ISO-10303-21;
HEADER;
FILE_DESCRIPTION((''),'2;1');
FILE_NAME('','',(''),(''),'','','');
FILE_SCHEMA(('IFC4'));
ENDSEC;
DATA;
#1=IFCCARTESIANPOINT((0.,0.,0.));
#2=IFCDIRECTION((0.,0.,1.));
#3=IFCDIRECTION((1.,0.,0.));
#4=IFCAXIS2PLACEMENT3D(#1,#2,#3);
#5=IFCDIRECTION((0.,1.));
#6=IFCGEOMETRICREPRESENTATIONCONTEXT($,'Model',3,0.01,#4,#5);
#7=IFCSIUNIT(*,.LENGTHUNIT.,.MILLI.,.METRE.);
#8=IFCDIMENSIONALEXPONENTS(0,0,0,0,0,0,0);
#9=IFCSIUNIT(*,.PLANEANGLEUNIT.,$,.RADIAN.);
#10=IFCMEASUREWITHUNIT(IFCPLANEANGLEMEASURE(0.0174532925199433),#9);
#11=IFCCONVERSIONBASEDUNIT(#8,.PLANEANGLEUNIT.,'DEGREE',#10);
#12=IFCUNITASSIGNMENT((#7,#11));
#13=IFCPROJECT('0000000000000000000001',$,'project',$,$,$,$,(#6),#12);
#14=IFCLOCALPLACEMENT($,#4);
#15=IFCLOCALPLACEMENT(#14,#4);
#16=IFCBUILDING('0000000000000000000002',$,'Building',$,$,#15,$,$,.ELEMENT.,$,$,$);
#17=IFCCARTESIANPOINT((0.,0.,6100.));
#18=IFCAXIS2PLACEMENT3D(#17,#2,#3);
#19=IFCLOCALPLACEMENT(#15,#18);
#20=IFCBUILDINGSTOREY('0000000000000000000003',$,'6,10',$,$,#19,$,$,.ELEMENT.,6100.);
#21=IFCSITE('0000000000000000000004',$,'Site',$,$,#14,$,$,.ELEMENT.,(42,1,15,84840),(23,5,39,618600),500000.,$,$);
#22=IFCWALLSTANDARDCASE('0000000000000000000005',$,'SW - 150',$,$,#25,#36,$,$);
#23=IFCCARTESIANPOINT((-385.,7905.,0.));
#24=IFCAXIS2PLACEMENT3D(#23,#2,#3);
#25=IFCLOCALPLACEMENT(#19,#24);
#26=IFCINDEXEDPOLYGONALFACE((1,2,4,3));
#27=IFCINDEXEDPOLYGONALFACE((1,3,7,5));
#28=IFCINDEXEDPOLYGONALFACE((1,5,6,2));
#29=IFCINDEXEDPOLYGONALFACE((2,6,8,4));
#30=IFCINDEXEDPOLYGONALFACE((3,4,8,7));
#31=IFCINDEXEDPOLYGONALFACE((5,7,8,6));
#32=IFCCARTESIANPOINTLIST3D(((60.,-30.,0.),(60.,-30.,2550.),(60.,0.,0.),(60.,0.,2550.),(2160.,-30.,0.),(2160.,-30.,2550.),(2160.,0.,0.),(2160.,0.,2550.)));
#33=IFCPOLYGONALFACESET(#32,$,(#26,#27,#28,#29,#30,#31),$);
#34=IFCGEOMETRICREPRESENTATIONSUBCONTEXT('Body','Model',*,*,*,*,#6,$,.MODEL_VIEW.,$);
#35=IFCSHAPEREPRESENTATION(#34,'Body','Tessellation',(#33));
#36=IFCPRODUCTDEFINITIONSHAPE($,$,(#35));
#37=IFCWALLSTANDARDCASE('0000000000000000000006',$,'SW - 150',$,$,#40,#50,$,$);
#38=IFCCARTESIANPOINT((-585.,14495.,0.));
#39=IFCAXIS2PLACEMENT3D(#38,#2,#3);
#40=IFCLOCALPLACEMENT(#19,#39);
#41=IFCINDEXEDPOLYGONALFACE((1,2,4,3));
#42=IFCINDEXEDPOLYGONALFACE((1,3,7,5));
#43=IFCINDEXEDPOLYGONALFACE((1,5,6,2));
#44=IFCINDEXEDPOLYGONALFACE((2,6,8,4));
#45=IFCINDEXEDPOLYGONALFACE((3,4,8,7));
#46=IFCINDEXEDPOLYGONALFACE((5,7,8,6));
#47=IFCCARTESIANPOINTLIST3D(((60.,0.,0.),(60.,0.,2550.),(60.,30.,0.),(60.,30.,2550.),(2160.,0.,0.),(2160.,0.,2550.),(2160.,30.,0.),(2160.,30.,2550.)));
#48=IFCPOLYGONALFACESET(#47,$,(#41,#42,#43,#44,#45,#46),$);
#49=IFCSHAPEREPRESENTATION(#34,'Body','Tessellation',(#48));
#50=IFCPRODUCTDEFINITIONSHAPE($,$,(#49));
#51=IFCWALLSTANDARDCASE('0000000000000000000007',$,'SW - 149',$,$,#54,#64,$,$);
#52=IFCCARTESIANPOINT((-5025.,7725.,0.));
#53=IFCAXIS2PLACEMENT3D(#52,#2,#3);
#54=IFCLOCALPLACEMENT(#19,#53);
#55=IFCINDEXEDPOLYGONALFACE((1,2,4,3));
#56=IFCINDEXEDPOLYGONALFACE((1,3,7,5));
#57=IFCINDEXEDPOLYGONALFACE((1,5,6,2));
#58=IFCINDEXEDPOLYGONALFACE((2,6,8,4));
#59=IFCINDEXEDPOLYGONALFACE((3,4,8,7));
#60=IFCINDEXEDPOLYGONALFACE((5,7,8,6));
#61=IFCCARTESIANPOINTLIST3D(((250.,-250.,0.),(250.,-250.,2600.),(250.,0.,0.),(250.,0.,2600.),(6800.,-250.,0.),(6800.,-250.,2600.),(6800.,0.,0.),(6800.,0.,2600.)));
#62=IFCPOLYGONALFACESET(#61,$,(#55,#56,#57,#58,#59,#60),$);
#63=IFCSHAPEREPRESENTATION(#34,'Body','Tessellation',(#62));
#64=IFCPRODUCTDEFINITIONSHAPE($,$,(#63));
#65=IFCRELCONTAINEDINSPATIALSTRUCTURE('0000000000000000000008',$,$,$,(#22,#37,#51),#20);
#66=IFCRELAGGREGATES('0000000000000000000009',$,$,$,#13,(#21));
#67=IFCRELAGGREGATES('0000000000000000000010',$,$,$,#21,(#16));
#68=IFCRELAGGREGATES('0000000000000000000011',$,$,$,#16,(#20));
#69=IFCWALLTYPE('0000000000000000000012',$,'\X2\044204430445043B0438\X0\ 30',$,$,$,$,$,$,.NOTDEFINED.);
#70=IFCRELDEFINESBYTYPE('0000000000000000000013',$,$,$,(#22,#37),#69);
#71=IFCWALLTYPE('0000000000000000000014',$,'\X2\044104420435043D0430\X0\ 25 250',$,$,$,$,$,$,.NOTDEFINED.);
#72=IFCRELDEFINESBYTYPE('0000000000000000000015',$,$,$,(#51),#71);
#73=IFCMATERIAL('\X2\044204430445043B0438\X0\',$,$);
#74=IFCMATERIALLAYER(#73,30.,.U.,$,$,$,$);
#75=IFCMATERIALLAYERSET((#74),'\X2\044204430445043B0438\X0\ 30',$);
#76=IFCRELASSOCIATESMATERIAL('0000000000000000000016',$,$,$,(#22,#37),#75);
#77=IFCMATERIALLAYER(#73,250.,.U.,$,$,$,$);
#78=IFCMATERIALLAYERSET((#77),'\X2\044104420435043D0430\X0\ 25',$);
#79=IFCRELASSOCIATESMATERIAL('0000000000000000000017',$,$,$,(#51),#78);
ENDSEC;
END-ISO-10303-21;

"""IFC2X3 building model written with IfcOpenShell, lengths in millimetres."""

from ifc_helpers import new_model, entity, si_unit, converted_unit, direction, frame, origin_with_axes, place, context, subcontext, project, spatial, polyline, outline, extrude, material, layer, layer_set, layer_usage, type_object, element, save


model = new_model("IFC2X3")

# Units and contexts
model_context = context("Model", 3, precision=0.01, world=origin_with_axes(), true_north=direction((0.0, 1.0)))
body_context = subcontext(model_context, "Body", "Model", "MODEL_VIEW")
ifc_project = project(units=[si_unit("LENGTHUNIT", "METRE", prefix="MILLI"), converted_unit("PLANEANGLEUNIT", "DEGREE", entity("IfcPlaneAngleMeasure", 0.0174532925199433), si_unit("PLANEANGLEUNIT", "RADIAN"), dimensions=[0, 0, 0, 0, 0, 0, 0])], contexts=[model_context])

# Site, building, storey
site_placement = place(None, origin_with_axes())
site = spatial("IfcSite", under=ifc_project, at=site_placement, Name="Site", CompositionType="ELEMENT", RefLatitude=(42, 1, 15, 84840), RefLongitude=(23, 5, 39, 618600), RefElevation=500000.0)
building_placement = place(site_placement, origin_with_axes())
building = spatial("IfcBuilding", under=site, at=building_placement, Name="Building", CompositionType="ELEMENT")
storey_placement = place(building_placement, frame((0.0, 0.0, 6100.0), z_axis=(0.0, 0.0, 1.0), x_axis=(1.0, 0.0, 0.0)))
storey = spatial("IfcBuildingStorey", under=building, at=storey_placement, Name="6,10", CompositionType="ELEMENT", Elevation=6100.0)

# Shared definitions
ifc_material_1 = material(Name="тухли")

# Walls
ifc_layer_1 = layer(ifc_material_1, 30.0, ventilated="UNKNOWN")
ifc_layer_set_1 = layer_set([ifc_layer_1], Name="тухли 30")
ifc_layer_usage_1 = layer_usage(ifc_layer_set_1, "AXIS2", "NEGATIVE", 0.0)
wall_type_1 = type_object("IfcWallType", Name="тухли 30", PredefinedType="NOTDEFINED")
wall_1_placement = place(storey_placement, frame((-385.0, 7905.0, 0.0), z_axis=(0.0, 0.0, 1.0), x_axis=(1.0, 0.0, 0.0)))
element("IfcWallStandardCase", 1, at=wall_1_placement, inside=storey, type_object=wall_type_1, material=ifc_layer_usage_1, Name="SW - 150", context=body_context, shape_type="SweptSolid", body=[
    extrude(outline(polyline([(60.0, -30.0), (2160.0, -30.0), (2160.0, 0.0), (60.0, 0.0), (60.0, -30.0)])), origin_with_axes(), (0.0, 0.0, 1.0), 2550.0),
])
ifc_layer_usage_2 = layer_usage(ifc_layer_set_1, "AXIS2", "POSITIVE", 0.0)
wall_2_placement = place(storey_placement, frame((-585.0, 14495.0, 0.0), z_axis=(0.0, 0.0, 1.0), x_axis=(1.0, 0.0, 0.0)))
element("IfcWallStandardCase", 2, at=wall_2_placement, inside=storey, type_object=wall_type_1, material=ifc_layer_usage_2, Name="SW - 150", context=body_context, shape_type="SweptSolid", body=[
    extrude(outline(polyline([(60.0, 0.0), (2160.0, 0.0), (2160.0, 30.0), (60.0, 30.0), (60.0, 0.0)])), origin_with_axes(), (0.0, 0.0, 1.0), 2550.0),
])
ifc_layer_2 = layer(ifc_material_1, 250.0, ventilated="UNKNOWN")
ifc_layer_set_2 = layer_set([ifc_layer_2], Name="стена 25")
ifc_layer_usage_3 = layer_usage(ifc_layer_set_2, "AXIS2", "NEGATIVE", 0.0)
wall_type_2 = type_object("IfcWallType", Name="стена 25 250", PredefinedType="NOTDEFINED")
wall_3_placement = place(storey_placement, frame((-5025.0, 7725.0, 0.0), z_axis=(0.0, 0.0, 1.0), x_axis=(1.0, 0.0, 0.0)))
element("IfcWallStandardCase", 3, at=wall_3_placement, inside=storey, type_object=wall_type_2, material=ifc_layer_usage_3, Name="SW - 149", context=body_context, shape_type="SweptSolid", body=[
    extrude(outline(polyline([(250.0, -250.0), (6800.0, -250.0), (6800.0, 0.0), (250.0, 0.0), (250.0, -250.0)])), origin_with_axes(), (0.0, 0.0, 1.0), 2600.0),
])

save(model, "model.ifc")
